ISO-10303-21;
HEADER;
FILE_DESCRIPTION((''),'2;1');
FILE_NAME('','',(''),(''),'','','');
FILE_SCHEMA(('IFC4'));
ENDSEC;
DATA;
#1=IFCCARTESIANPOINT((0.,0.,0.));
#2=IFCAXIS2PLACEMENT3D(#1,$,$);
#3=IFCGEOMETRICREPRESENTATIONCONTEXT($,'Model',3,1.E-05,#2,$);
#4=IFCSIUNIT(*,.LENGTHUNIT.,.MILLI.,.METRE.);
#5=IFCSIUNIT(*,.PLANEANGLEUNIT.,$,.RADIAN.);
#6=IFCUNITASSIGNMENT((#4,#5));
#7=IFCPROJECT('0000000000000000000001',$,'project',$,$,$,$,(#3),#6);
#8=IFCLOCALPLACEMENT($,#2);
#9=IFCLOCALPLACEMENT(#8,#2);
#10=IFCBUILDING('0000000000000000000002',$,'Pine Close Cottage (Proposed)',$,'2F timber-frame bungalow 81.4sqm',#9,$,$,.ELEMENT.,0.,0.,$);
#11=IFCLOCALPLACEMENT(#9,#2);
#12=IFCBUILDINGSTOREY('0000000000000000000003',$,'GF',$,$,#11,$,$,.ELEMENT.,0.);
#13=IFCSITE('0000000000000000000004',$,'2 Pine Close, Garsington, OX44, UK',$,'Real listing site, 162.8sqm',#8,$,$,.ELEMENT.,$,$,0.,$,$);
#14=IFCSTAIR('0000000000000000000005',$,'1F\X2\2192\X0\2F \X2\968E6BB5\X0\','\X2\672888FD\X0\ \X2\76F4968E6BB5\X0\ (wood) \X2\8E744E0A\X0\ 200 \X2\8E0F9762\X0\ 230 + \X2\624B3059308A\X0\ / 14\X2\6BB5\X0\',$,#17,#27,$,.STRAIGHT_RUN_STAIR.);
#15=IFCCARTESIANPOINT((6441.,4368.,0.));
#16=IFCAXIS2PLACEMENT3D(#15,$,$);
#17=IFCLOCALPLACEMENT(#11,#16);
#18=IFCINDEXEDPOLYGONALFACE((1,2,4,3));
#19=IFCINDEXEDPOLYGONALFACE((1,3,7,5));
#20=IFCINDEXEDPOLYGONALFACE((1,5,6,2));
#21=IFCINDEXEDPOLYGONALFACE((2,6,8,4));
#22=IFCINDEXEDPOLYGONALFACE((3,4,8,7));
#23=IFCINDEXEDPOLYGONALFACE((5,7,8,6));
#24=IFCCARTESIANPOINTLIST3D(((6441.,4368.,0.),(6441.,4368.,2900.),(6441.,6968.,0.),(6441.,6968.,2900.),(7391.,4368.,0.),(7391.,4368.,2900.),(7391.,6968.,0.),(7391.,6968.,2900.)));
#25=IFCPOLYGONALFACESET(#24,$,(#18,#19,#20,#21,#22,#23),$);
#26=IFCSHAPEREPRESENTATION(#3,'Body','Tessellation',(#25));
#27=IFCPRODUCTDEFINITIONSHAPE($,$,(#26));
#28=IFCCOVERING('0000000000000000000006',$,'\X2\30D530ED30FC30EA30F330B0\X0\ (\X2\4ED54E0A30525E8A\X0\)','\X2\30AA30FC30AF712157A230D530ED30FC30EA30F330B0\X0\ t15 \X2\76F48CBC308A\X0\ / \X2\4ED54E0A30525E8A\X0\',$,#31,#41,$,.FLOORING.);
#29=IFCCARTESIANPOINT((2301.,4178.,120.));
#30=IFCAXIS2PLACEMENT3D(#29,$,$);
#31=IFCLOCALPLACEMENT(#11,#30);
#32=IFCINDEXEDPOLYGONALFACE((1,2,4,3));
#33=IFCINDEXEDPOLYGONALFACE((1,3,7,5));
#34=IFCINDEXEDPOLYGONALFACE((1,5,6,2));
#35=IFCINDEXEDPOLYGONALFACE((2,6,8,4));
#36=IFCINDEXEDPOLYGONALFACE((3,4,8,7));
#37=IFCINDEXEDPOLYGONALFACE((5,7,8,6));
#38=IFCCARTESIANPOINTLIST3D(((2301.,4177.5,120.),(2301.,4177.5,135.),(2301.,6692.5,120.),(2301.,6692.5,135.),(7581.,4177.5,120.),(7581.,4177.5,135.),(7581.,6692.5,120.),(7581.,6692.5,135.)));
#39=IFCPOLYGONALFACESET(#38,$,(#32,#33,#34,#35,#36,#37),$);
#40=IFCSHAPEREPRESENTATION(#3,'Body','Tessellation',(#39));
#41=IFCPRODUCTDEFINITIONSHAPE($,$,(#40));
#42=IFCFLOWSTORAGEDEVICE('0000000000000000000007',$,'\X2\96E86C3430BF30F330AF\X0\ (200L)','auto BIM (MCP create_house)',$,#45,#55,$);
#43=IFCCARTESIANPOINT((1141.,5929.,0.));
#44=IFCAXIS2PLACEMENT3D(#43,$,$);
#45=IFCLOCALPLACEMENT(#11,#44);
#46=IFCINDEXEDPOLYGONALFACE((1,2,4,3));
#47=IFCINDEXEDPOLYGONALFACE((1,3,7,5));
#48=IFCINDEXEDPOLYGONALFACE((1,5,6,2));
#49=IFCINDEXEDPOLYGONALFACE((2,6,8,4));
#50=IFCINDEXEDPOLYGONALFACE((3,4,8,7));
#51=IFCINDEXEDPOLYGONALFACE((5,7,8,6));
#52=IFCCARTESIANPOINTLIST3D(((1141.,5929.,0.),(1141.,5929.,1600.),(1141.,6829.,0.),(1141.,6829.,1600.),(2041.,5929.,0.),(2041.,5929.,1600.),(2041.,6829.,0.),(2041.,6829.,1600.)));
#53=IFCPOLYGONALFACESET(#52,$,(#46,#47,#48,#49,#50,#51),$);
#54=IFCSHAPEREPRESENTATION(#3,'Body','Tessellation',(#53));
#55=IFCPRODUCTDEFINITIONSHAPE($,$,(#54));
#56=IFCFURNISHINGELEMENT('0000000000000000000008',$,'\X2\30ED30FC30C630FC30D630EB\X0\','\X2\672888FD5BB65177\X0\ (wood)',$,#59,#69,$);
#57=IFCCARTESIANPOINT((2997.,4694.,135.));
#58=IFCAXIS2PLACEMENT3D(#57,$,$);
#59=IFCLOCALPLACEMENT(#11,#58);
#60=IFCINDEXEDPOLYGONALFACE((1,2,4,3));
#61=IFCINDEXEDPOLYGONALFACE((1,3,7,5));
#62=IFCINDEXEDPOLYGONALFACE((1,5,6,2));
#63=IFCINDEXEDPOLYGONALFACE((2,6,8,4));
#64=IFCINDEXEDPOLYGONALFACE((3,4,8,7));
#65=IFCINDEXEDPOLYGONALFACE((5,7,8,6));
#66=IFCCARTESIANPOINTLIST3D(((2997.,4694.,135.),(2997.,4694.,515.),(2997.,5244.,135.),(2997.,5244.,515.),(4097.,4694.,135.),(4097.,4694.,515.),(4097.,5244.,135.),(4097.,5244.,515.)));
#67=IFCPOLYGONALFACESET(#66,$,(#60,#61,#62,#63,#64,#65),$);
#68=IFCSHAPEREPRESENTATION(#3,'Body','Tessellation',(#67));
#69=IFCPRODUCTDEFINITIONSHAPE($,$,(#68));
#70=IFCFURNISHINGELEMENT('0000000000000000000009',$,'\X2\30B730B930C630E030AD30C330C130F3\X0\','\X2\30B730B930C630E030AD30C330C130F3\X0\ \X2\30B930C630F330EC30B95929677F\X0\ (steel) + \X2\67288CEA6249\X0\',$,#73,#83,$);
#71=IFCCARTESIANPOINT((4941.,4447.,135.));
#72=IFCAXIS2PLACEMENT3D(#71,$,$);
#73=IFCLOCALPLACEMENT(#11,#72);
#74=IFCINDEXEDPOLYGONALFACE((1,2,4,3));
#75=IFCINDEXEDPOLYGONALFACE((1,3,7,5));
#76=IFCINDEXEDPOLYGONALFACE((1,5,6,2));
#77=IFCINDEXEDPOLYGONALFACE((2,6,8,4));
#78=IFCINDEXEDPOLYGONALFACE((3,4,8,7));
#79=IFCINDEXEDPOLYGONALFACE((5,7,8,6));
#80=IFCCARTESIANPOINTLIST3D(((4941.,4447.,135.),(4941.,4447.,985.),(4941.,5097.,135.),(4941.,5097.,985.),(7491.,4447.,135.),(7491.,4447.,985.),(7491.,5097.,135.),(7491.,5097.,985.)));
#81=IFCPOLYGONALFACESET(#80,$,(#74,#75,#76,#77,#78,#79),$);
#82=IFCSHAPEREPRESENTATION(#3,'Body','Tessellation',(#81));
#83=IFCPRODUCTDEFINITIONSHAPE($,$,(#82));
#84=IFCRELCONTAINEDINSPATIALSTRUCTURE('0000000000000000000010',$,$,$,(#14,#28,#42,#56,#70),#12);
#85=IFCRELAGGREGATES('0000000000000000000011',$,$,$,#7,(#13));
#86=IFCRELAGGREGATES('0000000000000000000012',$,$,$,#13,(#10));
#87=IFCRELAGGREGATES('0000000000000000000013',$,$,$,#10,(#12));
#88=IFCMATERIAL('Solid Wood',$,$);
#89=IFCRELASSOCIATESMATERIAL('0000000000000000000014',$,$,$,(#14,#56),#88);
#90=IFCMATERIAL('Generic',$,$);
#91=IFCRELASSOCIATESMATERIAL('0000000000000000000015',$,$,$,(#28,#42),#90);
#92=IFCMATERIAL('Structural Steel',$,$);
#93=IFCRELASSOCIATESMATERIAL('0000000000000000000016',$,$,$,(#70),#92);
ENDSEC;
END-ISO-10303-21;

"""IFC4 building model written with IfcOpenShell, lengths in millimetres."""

from ifc_helpers import new_model, si_unit, frame, frame_2d, origin, place, context, project, spatial, rectangle, extrude, material, element, save


model = new_model("IFC4")

# Units and contexts
model_context = context("Model", 3, precision=1e-05, world=origin())
ifc_project = project(units=[si_unit("LENGTHUNIT", "METRE", prefix="MILLI"), si_unit("PLANEANGLEUNIT", "RADIAN")], contexts=[model_context])

# Site, building, storey
site_placement = place(None, origin())
site = spatial("IfcSite", under=ifc_project, at=site_placement, Name="2 Pine Close, Garsington, OX44, UK", ObjectType="Real listing site, 162.8sqm", CompositionType="ELEMENT", RefElevation=0.0)
building_placement = place(site_placement, origin())
building = spatial("IfcBuilding", under=site, at=building_placement, Name="Pine Close Cottage (Proposed)", ObjectType="2F timber-frame bungalow 81.4sqm", CompositionType="ELEMENT", ElevationOfRefHeight=0.0, ElevationOfTerrain=0.0)
storey_placement = place(building_placement, origin())
storey = spatial("IfcBuildingStorey", under=building, at=storey_placement, Name="GF", CompositionType="ELEMENT", Elevation=0.0)

# Shared definitions
ifc_material_1 = material(Name="Solid Wood")

# Stair
stair_placement = place(storey_placement, frame((6441.0, 4368.0, 0.0)))
element("IfcStair", 1, at=stair_placement, inside=storey, material=ifc_material_1, Name="1F→2F 階段", Description="木製 直階段 (wood) 蹴上 200 踏面 230 + 手すり / 14段", PredefinedType="STRAIGHT_RUN_STAIR", context=model_context, shape_type="SweptSolid", body=[
    extrude(rectangle(XDim=950.0, YDim=2600.0, at=frame_2d((475.0, 1300.0))), frame((6441.0, 4368.0, 0.0)), (0.0, 0.0, 1.0), 2900.0),
])

# Covering
ifc_material_2 = material(Name="Generic")
covering_placement = place(storey_placement, frame((2301.0, 4178.0, 120.0)))
element("IfcCovering", 2, at=covering_placement, inside=storey, material=ifc_material_2, Name="フローリング (仕上げ床)", Description="オーク無垢フローリング t15 直貼り / 仕上げ床", PredefinedType="FLOORING", context=model_context, shape_type="SweptSolid", body=[
    extrude(rectangle(XDim=5280.0, YDim=2515.0, at=frame_2d((2640.0, 1257.0))), frame((2301.0, 4178.0, 120.0)), (0.0, 0.0, 1.0), 15.0),
])

# Flow storage device
flow_storage_device_placement = place(storey_placement, frame((1141.0, 5929.0, 0.0)))
element("IfcFlowStorageDevice", 3, at=flow_storage_device_placement, inside=storey, material=ifc_material_2, Name="雨水タンク (200L)", Description="auto BIM (MCP create_house)", context=model_context, shape_type="SweptSolid", body=[
    extrude(rectangle(XDim=900.0, YDim=900.0, at=frame_2d((450.0, 450.0))), frame((1141.0, 5929.0, 0.0)), (0.0, 0.0, 1.0), 1600.0),
])

# Furnishing elements
furnishing_1_placement = place(storey_placement, frame((2997.0, 4694.0, 135.0)))
element("IfcFurnishingElement", 4, at=furnishing_1_placement, inside=storey, material=ifc_material_1, Name="ローテーブル", Description="木製家具 (wood)", context=model_context, shape_type="SweptSolid", body=[
    extrude(rectangle(XDim=1100.0, YDim=550.0, at=frame_2d((550.0, 275.0))), frame((2997.0, 4694.0, 135.0)), (0.0, 0.0, 1.0), 380.0),
])
ifc_material_3 = material(Name="Structural Steel")
furnishing_2_placement = place(storey_placement, frame((4941.0, 4447.0, 135.0)))
element("IfcFurnishingElement", 5, at=furnishing_2_placement, inside=storey, material=ifc_material_3, Name="システムキッチン", Description="システムキッチン ステンレス天板 (steel) + 木質扉", context=model_context, shape_type="SweptSolid", body=[
    extrude(rectangle(XDim=2550.0, YDim=650.0, at=frame_2d((1275.0, 325.0))), frame((4941.0, 4447.0, 135.0)), (0.0, 0.0, 1.0), 850.0),
])

save(model, "model.ifc")
